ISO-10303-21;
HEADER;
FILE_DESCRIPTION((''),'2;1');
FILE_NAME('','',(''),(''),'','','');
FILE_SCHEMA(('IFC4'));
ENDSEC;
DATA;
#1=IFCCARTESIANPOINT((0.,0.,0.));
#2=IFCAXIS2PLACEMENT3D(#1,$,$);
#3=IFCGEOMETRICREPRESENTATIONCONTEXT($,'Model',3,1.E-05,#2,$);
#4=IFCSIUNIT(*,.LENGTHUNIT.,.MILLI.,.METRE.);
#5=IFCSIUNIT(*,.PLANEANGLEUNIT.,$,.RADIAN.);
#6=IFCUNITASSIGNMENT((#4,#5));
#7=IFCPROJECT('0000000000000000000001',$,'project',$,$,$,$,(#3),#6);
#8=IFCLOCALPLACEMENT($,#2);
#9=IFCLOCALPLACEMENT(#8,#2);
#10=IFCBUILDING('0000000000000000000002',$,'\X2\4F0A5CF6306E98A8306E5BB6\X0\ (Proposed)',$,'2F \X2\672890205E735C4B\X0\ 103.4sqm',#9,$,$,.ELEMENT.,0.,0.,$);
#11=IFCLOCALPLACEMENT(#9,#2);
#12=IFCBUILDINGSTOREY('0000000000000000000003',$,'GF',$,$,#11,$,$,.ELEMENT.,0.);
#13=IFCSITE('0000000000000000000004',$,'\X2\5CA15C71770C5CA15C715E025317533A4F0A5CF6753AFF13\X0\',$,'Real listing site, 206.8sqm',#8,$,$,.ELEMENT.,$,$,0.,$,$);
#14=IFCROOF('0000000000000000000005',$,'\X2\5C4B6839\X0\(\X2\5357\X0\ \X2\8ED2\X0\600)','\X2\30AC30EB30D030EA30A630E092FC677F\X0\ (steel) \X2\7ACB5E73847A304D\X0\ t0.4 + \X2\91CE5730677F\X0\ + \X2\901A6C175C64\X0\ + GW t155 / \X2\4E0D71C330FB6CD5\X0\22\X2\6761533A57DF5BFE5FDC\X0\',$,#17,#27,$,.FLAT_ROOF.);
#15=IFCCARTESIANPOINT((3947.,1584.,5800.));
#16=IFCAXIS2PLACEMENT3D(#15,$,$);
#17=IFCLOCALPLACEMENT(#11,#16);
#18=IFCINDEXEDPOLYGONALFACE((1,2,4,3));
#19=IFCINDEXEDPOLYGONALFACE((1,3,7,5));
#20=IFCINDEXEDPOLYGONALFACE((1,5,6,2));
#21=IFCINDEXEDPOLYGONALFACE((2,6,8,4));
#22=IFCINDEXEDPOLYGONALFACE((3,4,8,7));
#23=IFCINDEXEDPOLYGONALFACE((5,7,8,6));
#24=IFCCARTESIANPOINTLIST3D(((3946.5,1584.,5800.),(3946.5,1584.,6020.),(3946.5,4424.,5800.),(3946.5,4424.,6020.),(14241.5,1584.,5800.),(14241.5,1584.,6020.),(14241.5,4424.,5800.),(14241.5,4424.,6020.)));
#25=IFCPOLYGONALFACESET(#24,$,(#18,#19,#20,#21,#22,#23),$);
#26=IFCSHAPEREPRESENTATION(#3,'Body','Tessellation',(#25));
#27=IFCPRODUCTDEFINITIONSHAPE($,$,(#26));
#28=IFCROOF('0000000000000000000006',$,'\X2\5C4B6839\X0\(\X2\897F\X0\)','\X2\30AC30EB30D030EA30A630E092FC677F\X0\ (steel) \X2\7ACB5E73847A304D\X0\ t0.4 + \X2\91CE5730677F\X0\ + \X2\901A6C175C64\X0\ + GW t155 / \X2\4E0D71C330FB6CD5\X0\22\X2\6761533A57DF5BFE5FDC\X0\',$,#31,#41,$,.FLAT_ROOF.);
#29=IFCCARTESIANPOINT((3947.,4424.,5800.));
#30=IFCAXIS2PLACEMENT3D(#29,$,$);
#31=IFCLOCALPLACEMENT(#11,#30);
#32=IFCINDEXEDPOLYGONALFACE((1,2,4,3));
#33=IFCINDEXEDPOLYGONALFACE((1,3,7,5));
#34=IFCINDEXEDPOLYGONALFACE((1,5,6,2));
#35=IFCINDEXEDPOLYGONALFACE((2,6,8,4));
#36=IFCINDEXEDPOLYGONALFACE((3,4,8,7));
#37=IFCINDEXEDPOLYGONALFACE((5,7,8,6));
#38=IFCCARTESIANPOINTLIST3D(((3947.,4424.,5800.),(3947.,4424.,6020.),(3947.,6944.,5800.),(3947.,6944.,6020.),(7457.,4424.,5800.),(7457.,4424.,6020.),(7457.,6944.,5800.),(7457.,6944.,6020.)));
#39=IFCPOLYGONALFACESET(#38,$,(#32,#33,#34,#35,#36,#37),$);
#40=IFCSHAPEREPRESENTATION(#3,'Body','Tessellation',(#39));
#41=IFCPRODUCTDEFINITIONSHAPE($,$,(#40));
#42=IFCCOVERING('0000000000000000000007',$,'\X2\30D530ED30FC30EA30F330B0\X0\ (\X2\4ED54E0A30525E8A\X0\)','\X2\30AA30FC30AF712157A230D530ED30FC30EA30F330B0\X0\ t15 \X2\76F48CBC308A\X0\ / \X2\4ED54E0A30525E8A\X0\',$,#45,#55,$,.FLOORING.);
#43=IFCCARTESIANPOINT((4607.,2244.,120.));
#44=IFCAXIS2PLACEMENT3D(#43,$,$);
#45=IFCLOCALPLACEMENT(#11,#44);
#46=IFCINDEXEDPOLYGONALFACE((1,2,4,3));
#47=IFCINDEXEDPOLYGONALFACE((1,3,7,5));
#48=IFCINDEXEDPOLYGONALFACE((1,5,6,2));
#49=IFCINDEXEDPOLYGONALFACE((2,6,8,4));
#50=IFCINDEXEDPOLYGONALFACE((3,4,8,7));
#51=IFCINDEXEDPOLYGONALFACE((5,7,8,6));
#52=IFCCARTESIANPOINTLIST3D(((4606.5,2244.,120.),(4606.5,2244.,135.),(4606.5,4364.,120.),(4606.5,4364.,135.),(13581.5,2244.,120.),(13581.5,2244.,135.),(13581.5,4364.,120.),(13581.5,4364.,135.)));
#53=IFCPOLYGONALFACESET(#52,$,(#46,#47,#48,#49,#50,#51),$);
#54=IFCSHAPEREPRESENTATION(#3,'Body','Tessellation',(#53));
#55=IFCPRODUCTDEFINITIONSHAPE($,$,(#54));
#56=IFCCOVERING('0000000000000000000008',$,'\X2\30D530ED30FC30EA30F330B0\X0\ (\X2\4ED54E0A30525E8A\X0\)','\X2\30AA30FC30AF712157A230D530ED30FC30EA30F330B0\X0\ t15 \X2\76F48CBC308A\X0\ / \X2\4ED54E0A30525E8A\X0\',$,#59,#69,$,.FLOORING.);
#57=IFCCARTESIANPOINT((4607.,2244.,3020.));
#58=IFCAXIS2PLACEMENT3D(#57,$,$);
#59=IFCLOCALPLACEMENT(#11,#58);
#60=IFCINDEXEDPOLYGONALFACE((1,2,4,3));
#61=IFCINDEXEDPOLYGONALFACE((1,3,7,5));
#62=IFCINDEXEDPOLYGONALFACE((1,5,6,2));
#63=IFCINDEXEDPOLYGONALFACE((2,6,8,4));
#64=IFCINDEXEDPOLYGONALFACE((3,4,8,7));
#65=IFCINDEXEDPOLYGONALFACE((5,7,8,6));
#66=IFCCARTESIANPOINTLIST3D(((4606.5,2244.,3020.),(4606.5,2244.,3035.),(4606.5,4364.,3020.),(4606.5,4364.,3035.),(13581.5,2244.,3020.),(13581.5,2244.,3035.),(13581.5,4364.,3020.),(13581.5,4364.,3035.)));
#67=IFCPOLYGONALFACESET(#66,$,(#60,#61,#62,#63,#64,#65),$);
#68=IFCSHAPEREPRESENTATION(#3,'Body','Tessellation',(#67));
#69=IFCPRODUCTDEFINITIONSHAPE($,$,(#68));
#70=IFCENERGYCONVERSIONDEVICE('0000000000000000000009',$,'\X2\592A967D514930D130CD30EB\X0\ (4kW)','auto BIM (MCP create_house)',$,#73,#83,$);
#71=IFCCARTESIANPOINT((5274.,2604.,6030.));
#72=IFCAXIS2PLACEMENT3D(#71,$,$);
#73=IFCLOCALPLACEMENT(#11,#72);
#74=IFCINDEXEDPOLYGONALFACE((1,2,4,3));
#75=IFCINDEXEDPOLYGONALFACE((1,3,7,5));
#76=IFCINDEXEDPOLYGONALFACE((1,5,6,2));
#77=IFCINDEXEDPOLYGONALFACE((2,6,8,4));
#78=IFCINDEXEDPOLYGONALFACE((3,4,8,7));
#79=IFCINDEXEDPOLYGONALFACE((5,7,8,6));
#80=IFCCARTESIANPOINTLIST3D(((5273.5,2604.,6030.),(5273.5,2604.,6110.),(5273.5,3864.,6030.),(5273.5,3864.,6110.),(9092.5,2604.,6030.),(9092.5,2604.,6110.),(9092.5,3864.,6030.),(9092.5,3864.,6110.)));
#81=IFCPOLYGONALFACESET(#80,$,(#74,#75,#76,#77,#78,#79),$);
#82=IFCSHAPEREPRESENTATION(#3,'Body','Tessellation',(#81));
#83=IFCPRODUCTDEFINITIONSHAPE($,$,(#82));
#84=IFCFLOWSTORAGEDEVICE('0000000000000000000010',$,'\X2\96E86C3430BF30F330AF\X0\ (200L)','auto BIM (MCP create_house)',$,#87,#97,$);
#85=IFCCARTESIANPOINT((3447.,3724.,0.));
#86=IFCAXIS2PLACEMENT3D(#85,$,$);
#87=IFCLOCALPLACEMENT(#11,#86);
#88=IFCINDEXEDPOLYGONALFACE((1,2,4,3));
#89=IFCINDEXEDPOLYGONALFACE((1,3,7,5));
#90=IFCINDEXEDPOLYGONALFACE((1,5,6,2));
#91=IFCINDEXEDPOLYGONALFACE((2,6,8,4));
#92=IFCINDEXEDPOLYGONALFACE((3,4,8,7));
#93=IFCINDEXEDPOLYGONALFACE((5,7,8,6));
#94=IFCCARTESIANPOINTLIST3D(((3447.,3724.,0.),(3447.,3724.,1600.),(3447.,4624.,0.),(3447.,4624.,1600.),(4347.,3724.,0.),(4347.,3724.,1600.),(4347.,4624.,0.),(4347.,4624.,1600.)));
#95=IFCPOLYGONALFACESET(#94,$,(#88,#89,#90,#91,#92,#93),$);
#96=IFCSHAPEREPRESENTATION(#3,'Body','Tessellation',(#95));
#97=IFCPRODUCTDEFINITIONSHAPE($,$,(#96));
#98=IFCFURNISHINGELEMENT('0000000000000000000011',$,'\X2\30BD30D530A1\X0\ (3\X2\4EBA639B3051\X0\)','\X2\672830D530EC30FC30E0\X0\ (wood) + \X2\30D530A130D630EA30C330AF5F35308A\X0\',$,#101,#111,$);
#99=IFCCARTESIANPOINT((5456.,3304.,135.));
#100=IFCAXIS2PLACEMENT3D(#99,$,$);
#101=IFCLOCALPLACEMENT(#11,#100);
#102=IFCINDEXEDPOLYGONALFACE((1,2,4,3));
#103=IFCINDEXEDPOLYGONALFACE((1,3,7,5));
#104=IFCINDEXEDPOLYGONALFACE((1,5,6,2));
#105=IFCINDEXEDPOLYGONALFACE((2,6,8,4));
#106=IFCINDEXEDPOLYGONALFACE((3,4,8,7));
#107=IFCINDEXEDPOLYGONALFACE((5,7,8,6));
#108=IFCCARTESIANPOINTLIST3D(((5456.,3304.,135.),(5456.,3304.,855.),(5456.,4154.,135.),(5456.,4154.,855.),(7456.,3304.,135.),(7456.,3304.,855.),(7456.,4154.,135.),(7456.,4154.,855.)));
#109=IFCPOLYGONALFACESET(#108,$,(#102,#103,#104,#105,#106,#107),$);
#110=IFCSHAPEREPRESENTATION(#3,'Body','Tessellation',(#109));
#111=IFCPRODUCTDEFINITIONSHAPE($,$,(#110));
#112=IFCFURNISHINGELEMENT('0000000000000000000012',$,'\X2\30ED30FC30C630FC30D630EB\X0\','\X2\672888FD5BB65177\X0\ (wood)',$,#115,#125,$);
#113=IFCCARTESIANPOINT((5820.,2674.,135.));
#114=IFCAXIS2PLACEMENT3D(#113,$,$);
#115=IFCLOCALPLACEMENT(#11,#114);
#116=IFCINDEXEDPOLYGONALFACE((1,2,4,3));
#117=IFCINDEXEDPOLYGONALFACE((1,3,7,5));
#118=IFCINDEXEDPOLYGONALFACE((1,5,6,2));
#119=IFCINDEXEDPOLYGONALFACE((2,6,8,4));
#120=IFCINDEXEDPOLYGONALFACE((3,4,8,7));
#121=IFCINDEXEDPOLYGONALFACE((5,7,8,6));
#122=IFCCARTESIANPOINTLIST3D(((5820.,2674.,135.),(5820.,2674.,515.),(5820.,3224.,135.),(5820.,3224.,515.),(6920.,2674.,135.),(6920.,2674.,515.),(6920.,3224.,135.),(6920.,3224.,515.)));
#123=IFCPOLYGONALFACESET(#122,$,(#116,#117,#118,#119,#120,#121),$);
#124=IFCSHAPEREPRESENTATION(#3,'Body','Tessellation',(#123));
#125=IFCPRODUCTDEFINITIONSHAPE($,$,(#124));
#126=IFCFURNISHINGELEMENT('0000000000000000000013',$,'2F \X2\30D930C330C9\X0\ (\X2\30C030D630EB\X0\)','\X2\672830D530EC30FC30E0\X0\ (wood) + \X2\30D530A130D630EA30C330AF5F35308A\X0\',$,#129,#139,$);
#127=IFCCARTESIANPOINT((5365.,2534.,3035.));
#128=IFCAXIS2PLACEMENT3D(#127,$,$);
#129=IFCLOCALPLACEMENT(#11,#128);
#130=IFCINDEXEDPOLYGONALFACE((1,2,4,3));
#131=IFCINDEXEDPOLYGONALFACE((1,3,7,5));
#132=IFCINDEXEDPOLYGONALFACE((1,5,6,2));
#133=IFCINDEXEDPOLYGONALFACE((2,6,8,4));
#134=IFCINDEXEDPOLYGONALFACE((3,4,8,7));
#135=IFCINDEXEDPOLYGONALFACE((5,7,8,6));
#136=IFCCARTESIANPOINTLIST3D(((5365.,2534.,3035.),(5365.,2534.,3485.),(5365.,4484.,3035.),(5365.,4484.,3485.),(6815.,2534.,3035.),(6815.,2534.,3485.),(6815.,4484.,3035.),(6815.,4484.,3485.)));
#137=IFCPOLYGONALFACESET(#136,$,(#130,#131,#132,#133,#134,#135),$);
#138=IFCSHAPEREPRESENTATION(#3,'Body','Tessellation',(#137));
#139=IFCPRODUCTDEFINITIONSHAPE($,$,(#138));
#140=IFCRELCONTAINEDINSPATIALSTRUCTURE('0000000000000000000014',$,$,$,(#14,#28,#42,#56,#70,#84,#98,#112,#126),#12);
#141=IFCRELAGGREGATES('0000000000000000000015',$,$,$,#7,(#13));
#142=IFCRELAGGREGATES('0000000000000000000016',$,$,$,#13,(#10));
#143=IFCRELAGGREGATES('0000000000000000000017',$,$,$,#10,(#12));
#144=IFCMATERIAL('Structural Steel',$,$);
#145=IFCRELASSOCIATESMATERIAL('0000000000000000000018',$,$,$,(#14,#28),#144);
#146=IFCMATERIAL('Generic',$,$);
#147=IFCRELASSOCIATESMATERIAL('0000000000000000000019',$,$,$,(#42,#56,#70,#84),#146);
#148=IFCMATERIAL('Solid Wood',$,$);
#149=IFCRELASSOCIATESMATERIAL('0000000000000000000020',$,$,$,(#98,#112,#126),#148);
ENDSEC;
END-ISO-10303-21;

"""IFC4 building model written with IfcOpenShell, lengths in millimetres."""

from ifc_helpers import new_model, si_unit, frame, frame_2d, origin, place, context, project, spatial, rectangle, extrude, material, element, save


model = new_model("IFC4")

# Units and contexts
model_context = context("Model", 3, precision=1e-05, world=origin())
ifc_project = project(units=[si_unit("LENGTHUNIT", "METRE", prefix="MILLI"), si_unit("PLANEANGLEUNIT", "RADIAN")], contexts=[model_context])

# Site, building, storey
site_placement = place(None, origin())
site = spatial("IfcSite", under=ifc_project, at=site_placement, Name="岡山県岡山市北区伊島町３", ObjectType="Real listing site, 206.8sqm", CompositionType="ELEMENT", RefElevation=0.0)
building_placement = place(site_placement, origin())
building = spatial("IfcBuilding", under=site, at=building_placement, Name="伊島の風の家 (Proposed)", ObjectType="2F 木造平屋 103.4sqm", CompositionType="ELEMENT", ElevationOfRefHeight=0.0, ElevationOfTerrain=0.0)
storey_placement = place(building_placement, origin())
storey = spatial("IfcBuildingStorey", under=building, at=storey_placement, Name="GF", CompositionType="ELEMENT", Elevation=0.0)

# Shared definitions
ifc_material_1 = material(Name="Solid Wood")

# Roofs
ifc_material_2 = material(Name="Structural Steel")
roof_1_placement = place(storey_placement, frame((3947.0, 1584.0, 5800.0)))
element("IfcRoof", 1, at=roof_1_placement, inside=storey, material=ifc_material_2, Name="屋根(南 軒600)", Description="ガルバリウム鋼板 (steel) 立平葺き t0.4 + 野地板 + 通気層 + GW t155 / 不燃・法22条区域対応", PredefinedType="FLAT_ROOF", context=model_context, shape_type="SweptSolid", body=[
    extrude(rectangle(XDim=10295.0, YDim=2840.0, at=frame_2d((5147.0, 1420.0))), frame((3947.0, 1584.0, 5800.0)), (0.0, 0.0, 1.0), 220.0),
])
roof_2_placement = place(storey_placement, frame((3947.0, 4424.0, 5800.0)))
element("IfcRoof", 2, at=roof_2_placement, inside=storey, material=ifc_material_2, Name="屋根(西)", Description="ガルバリウム鋼板 (steel) 立平葺き t0.4 + 野地板 + 通気層 + GW t155 / 不燃・法22条区域対応", PredefinedType="FLAT_ROOF", context=model_context, shape_type="SweptSolid", body=[
    extrude(rectangle(XDim=3510.0, YDim=2520.0, at=frame_2d((1755.0, 1260.0))), frame((3947.0, 4424.0, 5800.0)), (0.0, 0.0, 1.0), 220.0),
])

# Coverings
ifc_material_3 = material(Name="Generic")
covering_1_placement = place(storey_placement, frame((4607.0, 2244.0, 120.0)))
element("IfcCovering", 3, at=covering_1_placement, inside=storey, material=ifc_material_3, Name="フローリング (仕上げ床)", Description="オーク無垢フローリング t15 直貼り / 仕上げ床", PredefinedType="FLOORING", context=model_context, shape_type="SweptSolid", body=[
    extrude(rectangle(XDim=8975.0, YDim=2120.0, at=frame_2d((4487.0, 1060.0))), frame((4607.0, 2244.0, 120.0)), (0.0, 0.0, 1.0), 15.0),
])
covering_2_placement = place(storey_placement, frame((4607.0, 2244.0, 3020.0)))
element("IfcCovering", 4, at=covering_2_placement, inside=storey, material=ifc_material_3, Name="フローリング (仕上げ床)", Description="オーク無垢フローリング t15 直貼り / 仕上げ床", PredefinedType="FLOORING", context=model_context, shape_type="SweptSolid", body=[
    extrude(rectangle(XDim=8975.0, YDim=2120.0, at=frame_2d((4487.0, 1060.0))), frame((4607.0, 2244.0, 3020.0)), (0.0, 0.0, 1.0), 15.0),
])

# Energy conversion device
energy_conversion_device_placement = place(storey_placement, frame((5274.0, 2604.0, 6030.0)))
element("IfcEnergyConversionDevice", 5, at=energy_conversion_device_placement, inside=storey, material=ifc_material_3, Name="太陽光パネル (4kW)", Description="auto BIM (MCP create_house)", context=model_context, shape_type="SweptSolid", body=[
    extrude(rectangle(XDim=3819.0, YDim=1260.0, at=frame_2d((1909.0, 630.0))), frame((5274.0, 2604.0, 6030.0)), (0.0, 0.0, 1.0), 80.0),
])

# Flow storage device
flow_storage_device_placement = place(storey_placement, frame((3447.0, 3724.0, 0.0)))
element("IfcFlowStorageDevice", 6, at=flow_storage_device_placement, inside=storey, material=ifc_material_3, Name="雨水タンク (200L)", Description="auto BIM (MCP create_house)", context=model_context, shape_type="SweptSolid", body=[
    extrude(rectangle(XDim=900.0, YDim=900.0, at=frame_2d((450.0, 450.0))), frame((3447.0, 3724.0, 0.0)), (0.0, 0.0, 1.0), 1600.0),
])

# Furnishing elements
furnishing_1_placement = place(storey_placement, frame((5456.0, 3304.0, 135.0)))
element("IfcFurnishingElement", 7, at=furnishing_1_placement, inside=storey, material=ifc_material_1, Name="ソファ (3人掛け)", Description="木フレーム (wood) + ファブリック張り", context=model_context, shape_type="SweptSolid", body=[
    extrude(rectangle(XDim=2000.0, YDim=850.0, at=frame_2d((1000.0, 425.0))), frame((5456.0, 3304.0, 135.0)), (0.0, 0.0, 1.0), 720.0),
])
furnishing_2_placement = place(storey_placement, frame((5820.0, 2674.0, 135.0)))
element("IfcFurnishingElement", 8, at=furnishing_2_placement, inside=storey, material=ifc_material_1, Name="ローテーブル", Description="木製家具 (wood)", context=model_context, shape_type="SweptSolid", body=[
    extrude(rectangle(XDim=1100.0, YDim=550.0, at=frame_2d((550.0, 275.0))), frame((5820.0, 2674.0, 135.0)), (0.0, 0.0, 1.0), 380.0),
])
furnishing_3_placement = place(storey_placement, frame((5365.0, 2534.0, 3035.0)))
element("IfcFurnishingElement", 9, at=furnishing_3_placement, inside=storey, material=ifc_material_1, Name="2F ベッド (ダブル)", Description="木フレーム (wood) + ファブリック張り", context=model_context, shape_type="SweptSolid", body=[
    extrude(rectangle(XDim=1450.0, YDim=1950.0, at=frame_2d((725.0, 975.0))), frame((5365.0, 2534.0, 3035.0)), (0.0, 0.0, 1.0), 450.0),
])

save(model, "model.ifc")
